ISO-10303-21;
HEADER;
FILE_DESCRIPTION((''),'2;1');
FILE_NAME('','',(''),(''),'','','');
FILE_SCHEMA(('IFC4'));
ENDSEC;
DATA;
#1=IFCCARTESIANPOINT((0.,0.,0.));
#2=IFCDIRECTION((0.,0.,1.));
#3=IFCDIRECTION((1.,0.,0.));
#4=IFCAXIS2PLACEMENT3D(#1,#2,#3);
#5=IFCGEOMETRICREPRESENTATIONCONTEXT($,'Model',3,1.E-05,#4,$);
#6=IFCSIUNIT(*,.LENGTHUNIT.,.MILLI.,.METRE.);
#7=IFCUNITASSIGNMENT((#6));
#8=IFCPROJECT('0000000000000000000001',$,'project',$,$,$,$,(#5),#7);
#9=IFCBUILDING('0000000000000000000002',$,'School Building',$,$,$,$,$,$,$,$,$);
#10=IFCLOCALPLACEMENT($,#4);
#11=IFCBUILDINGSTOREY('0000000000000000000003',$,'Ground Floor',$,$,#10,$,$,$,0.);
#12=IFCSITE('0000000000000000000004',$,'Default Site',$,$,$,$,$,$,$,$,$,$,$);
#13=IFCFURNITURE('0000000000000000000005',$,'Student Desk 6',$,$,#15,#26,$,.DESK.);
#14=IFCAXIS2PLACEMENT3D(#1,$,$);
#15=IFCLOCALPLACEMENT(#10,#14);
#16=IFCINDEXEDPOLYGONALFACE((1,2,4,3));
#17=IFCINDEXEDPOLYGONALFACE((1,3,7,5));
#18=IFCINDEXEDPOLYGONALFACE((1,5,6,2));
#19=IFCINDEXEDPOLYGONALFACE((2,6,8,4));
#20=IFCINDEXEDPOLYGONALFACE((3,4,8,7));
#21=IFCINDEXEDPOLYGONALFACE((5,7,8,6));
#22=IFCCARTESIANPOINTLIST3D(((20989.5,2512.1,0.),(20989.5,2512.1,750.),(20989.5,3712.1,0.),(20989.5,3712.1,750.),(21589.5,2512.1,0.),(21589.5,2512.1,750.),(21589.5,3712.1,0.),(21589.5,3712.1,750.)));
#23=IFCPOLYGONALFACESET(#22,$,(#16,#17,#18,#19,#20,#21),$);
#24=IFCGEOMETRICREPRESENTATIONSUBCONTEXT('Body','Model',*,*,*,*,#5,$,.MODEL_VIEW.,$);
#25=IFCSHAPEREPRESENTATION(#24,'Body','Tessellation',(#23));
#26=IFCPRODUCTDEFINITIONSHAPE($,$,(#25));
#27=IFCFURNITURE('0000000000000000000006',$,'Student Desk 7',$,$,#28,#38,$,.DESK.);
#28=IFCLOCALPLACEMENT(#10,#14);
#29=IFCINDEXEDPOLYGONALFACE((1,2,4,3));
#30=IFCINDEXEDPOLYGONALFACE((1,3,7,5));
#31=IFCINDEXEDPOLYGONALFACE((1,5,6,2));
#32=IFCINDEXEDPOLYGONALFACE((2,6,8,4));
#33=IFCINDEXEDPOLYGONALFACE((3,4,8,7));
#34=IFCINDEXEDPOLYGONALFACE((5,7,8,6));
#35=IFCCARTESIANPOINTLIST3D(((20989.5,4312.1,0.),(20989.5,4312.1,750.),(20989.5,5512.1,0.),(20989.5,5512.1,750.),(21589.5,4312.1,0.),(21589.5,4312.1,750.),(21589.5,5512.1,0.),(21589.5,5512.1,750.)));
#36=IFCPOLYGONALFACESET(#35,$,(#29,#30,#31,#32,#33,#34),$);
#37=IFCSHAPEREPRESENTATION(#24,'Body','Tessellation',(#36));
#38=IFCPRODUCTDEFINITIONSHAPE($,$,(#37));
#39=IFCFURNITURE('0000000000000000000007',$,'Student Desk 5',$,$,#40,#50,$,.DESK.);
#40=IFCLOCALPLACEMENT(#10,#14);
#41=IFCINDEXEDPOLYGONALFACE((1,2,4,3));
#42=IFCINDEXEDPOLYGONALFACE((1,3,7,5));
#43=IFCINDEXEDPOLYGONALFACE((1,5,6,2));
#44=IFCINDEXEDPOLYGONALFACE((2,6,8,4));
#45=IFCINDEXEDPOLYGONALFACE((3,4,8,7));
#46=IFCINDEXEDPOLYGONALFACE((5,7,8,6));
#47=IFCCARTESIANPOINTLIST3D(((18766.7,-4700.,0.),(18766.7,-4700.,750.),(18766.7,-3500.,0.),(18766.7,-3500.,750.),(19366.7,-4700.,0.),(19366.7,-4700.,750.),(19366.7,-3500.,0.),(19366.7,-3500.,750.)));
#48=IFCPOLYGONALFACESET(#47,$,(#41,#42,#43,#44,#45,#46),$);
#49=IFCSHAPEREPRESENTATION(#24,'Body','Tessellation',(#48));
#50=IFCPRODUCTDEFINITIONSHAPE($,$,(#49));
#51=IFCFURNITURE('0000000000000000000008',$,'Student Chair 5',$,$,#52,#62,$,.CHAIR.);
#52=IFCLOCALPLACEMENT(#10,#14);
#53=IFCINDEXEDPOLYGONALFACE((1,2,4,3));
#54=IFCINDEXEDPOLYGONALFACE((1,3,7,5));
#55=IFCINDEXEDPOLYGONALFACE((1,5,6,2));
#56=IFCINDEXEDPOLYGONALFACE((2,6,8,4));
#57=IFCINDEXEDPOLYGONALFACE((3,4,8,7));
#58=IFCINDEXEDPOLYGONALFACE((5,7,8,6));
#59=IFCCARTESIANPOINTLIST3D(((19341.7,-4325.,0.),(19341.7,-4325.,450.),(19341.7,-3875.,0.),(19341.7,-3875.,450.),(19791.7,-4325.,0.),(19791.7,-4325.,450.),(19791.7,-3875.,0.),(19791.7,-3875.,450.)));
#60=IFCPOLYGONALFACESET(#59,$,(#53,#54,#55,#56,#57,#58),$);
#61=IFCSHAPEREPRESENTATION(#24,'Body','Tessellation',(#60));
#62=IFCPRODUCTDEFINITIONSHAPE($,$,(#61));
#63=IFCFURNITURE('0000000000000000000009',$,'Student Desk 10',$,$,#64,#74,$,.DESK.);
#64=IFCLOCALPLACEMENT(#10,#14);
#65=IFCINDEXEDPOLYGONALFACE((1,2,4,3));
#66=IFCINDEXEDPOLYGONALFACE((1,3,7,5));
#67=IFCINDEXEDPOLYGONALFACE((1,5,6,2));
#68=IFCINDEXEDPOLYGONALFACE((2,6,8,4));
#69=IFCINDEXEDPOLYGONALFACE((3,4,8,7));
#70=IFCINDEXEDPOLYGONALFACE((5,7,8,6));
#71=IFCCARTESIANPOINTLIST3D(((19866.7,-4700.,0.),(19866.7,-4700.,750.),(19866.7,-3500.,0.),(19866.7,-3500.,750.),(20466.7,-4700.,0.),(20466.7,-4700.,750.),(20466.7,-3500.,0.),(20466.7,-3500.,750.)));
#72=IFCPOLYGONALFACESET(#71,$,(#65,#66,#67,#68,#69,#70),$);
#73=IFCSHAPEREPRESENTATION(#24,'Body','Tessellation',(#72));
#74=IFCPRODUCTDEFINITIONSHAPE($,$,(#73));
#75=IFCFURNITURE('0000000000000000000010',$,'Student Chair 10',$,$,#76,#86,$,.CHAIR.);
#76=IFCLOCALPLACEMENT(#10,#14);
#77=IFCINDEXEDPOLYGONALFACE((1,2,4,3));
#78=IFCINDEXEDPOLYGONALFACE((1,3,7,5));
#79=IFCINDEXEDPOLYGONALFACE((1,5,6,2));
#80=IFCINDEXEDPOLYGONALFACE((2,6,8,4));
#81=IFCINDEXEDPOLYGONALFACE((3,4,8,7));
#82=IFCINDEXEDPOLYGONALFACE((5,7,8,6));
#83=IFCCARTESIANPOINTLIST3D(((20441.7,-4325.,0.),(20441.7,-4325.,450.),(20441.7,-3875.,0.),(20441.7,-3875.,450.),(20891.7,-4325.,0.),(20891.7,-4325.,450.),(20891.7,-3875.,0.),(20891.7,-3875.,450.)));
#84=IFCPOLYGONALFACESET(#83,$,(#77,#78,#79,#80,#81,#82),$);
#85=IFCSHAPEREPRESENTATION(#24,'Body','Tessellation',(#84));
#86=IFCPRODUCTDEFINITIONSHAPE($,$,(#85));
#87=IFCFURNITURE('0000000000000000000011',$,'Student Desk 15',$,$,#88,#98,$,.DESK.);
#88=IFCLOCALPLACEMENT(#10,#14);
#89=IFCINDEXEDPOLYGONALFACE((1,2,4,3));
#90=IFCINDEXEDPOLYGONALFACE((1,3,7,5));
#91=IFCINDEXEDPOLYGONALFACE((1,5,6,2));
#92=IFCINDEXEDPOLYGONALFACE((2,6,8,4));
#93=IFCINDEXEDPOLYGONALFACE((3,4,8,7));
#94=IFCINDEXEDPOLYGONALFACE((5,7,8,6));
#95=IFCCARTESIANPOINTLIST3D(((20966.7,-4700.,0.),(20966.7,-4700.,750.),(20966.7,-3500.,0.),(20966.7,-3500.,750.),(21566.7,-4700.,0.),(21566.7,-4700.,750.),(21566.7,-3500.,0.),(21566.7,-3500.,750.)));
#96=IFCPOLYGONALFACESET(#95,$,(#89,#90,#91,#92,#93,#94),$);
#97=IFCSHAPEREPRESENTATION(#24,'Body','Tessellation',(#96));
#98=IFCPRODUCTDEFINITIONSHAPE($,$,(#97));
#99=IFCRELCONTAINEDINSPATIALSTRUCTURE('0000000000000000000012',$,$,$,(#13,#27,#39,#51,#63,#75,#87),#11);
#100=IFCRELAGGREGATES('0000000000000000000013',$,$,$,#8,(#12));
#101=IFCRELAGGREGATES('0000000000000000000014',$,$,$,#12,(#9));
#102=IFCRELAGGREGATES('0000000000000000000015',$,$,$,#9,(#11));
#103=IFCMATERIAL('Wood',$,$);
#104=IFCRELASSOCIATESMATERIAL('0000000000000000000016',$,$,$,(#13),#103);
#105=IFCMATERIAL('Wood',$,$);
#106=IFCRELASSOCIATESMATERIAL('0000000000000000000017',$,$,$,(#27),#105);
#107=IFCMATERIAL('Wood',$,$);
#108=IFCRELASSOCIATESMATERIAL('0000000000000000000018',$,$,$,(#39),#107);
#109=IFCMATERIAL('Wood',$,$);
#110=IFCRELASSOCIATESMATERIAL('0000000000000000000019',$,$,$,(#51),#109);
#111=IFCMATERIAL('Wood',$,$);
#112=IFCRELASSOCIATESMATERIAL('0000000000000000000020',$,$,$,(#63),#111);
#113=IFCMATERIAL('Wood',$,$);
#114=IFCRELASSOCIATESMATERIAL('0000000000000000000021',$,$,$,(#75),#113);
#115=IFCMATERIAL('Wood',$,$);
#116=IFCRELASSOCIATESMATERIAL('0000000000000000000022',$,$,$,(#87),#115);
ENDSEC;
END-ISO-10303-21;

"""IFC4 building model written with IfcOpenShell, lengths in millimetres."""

from ifc_helpers import new_model, si_unit, frame, origin_with_axes, origin_2d, place, context, subcontext, project, spatial, rectangle, extrude, material, element, save


model = new_model("IFC4")

# Units and contexts
model_context = context("Model", 3, precision=1e-05, world=origin_with_axes())
body_context = subcontext(model_context, "Body", "Model", "MODEL_VIEW")
ifc_project = project(units=[si_unit("LENGTHUNIT", "METRE", prefix="MILLI")], contexts=[model_context])

# Site, building, storey
site = spatial("IfcSite", under=ifc_project, Name="Default Site")
building = spatial("IfcBuilding", under=site, Name="School Building")
storey_placement = place(None, origin_with_axes())
storey = spatial("IfcBuildingStorey", under=building, at=storey_placement, Name="Ground Floor", Elevation=0.0)

# Furniture
ifc_material_1 = material(Name="Wood")
furniture_1_placement = place(storey_placement, frame((21289.5, 3112.1, 0.0), z_axis=(0.0, 0.0, 1.0), x_axis=(0.0, 1.0, 0.0)))
element("IfcFurniture", 1, at=furniture_1_placement, inside=storey, material=ifc_material_1, Name="Student Desk 6", PredefinedType="DESK", context=body_context, shape_type="SweptSolid", body=[
    extrude(rectangle(XDim=1200.0, YDim=600.0, at=origin_2d()), origin_with_axes(), (0.0, 0.0, 1.0), 750.0),
])
ifc_material_2 = material(Name="Wood")
furniture_2_placement = place(storey_placement, frame((21289.5, 4912.1, 0.0), z_axis=(0.0, 0.0, 1.0), x_axis=(0.0, 1.0, 0.0)))
element("IfcFurniture", 2, at=furniture_2_placement, inside=storey, material=ifc_material_2, Name="Student Desk 7", PredefinedType="DESK", context=body_context, shape_type="SweptSolid", body=[
    extrude(rectangle(XDim=1200.0, YDim=600.0, at=origin_2d()), origin_with_axes(), (0.0, 0.0, 1.0), 750.0),
])
ifc_material_3 = material(Name="Wood")
furniture_3_placement = place(storey_placement, frame((19066.7, -4100.0, 0.0), z_axis=(0.0, 0.0, 1.0), x_axis=(0.0, 1.0, 0.0)))
element("IfcFurniture", 3, at=furniture_3_placement, inside=storey, material=ifc_material_3, Name="Student Desk 5", PredefinedType="DESK", context=body_context, shape_type="SweptSolid", body=[
    extrude(rectangle(XDim=1200.0, YDim=600.0, at=origin_2d()), origin_with_axes(), (0.0, 0.0, 1.0), 750.0),
])
ifc_material_4 = material(Name="Wood")
furniture_4_placement = place(storey_placement, frame((19566.7, -4100.0, 0.0), z_axis=(0.0, 0.0, 1.0), x_axis=(1.0, 0.0, 0.0)))
element("IfcFurniture", 4, at=furniture_4_placement, inside=storey, material=ifc_material_4, Name="Student Chair 5", PredefinedType="CHAIR", context=body_context, shape_type="SweptSolid", body=[
    extrude(rectangle(XDim=450.0, YDim=450.0, at=origin_2d()), origin_with_axes(), (0.0, 0.0, 1.0), 450.0),
])
ifc_material_5 = material(Name="Wood")
furniture_5_placement = place(storey_placement, frame((20166.7, -4100.0, 0.0), z_axis=(0.0, 0.0, 1.0), x_axis=(0.0, 1.0, 0.0)))
element("IfcFurniture", 5, at=furniture_5_placement, inside=storey, material=ifc_material_5, Name="Student Desk 10", PredefinedType="DESK", context=body_context, shape_type="SweptSolid", body=[
    extrude(rectangle(XDim=1200.0, YDim=600.0, at=origin_2d()), origin_with_axes(), (0.0, 0.0, 1.0), 750.0),
])
ifc_material_6 = material(Name="Wood")
furniture_6_placement = place(storey_placement, frame((20666.7, -4100.0, 0.0), z_axis=(0.0, 0.0, 1.0), x_axis=(1.0, 0.0, 0.0)))
element("IfcFurniture", 6, at=furniture_6_placement, inside=storey, material=ifc_material_6, Name="Student Chair 10", PredefinedType="CHAIR", context=body_context, shape_type="SweptSolid", body=[
    extrude(rectangle(XDim=450.0, YDim=450.0, at=origin_2d()), origin_with_axes(), (0.0, 0.0, 1.0), 450.0),
])
ifc_material_7 = material(Name="Wood")
furniture_7_placement = place(storey_placement, frame((21266.7, -4100.0, 0.0), z_axis=(0.0, 0.0, 1.0), x_axis=(0.0, 1.0, 0.0)))
element("IfcFurniture", 7, at=furniture_7_placement, inside=storey, material=ifc_material_7, Name="Student Desk 15", PredefinedType="DESK", context=body_context, shape_type="SweptSolid", body=[
    extrude(rectangle(XDim=1200.0, YDim=600.0, at=origin_2d()), origin_with_axes(), (0.0, 0.0, 1.0), 750.0),
])

save(model, "model.ifc")
